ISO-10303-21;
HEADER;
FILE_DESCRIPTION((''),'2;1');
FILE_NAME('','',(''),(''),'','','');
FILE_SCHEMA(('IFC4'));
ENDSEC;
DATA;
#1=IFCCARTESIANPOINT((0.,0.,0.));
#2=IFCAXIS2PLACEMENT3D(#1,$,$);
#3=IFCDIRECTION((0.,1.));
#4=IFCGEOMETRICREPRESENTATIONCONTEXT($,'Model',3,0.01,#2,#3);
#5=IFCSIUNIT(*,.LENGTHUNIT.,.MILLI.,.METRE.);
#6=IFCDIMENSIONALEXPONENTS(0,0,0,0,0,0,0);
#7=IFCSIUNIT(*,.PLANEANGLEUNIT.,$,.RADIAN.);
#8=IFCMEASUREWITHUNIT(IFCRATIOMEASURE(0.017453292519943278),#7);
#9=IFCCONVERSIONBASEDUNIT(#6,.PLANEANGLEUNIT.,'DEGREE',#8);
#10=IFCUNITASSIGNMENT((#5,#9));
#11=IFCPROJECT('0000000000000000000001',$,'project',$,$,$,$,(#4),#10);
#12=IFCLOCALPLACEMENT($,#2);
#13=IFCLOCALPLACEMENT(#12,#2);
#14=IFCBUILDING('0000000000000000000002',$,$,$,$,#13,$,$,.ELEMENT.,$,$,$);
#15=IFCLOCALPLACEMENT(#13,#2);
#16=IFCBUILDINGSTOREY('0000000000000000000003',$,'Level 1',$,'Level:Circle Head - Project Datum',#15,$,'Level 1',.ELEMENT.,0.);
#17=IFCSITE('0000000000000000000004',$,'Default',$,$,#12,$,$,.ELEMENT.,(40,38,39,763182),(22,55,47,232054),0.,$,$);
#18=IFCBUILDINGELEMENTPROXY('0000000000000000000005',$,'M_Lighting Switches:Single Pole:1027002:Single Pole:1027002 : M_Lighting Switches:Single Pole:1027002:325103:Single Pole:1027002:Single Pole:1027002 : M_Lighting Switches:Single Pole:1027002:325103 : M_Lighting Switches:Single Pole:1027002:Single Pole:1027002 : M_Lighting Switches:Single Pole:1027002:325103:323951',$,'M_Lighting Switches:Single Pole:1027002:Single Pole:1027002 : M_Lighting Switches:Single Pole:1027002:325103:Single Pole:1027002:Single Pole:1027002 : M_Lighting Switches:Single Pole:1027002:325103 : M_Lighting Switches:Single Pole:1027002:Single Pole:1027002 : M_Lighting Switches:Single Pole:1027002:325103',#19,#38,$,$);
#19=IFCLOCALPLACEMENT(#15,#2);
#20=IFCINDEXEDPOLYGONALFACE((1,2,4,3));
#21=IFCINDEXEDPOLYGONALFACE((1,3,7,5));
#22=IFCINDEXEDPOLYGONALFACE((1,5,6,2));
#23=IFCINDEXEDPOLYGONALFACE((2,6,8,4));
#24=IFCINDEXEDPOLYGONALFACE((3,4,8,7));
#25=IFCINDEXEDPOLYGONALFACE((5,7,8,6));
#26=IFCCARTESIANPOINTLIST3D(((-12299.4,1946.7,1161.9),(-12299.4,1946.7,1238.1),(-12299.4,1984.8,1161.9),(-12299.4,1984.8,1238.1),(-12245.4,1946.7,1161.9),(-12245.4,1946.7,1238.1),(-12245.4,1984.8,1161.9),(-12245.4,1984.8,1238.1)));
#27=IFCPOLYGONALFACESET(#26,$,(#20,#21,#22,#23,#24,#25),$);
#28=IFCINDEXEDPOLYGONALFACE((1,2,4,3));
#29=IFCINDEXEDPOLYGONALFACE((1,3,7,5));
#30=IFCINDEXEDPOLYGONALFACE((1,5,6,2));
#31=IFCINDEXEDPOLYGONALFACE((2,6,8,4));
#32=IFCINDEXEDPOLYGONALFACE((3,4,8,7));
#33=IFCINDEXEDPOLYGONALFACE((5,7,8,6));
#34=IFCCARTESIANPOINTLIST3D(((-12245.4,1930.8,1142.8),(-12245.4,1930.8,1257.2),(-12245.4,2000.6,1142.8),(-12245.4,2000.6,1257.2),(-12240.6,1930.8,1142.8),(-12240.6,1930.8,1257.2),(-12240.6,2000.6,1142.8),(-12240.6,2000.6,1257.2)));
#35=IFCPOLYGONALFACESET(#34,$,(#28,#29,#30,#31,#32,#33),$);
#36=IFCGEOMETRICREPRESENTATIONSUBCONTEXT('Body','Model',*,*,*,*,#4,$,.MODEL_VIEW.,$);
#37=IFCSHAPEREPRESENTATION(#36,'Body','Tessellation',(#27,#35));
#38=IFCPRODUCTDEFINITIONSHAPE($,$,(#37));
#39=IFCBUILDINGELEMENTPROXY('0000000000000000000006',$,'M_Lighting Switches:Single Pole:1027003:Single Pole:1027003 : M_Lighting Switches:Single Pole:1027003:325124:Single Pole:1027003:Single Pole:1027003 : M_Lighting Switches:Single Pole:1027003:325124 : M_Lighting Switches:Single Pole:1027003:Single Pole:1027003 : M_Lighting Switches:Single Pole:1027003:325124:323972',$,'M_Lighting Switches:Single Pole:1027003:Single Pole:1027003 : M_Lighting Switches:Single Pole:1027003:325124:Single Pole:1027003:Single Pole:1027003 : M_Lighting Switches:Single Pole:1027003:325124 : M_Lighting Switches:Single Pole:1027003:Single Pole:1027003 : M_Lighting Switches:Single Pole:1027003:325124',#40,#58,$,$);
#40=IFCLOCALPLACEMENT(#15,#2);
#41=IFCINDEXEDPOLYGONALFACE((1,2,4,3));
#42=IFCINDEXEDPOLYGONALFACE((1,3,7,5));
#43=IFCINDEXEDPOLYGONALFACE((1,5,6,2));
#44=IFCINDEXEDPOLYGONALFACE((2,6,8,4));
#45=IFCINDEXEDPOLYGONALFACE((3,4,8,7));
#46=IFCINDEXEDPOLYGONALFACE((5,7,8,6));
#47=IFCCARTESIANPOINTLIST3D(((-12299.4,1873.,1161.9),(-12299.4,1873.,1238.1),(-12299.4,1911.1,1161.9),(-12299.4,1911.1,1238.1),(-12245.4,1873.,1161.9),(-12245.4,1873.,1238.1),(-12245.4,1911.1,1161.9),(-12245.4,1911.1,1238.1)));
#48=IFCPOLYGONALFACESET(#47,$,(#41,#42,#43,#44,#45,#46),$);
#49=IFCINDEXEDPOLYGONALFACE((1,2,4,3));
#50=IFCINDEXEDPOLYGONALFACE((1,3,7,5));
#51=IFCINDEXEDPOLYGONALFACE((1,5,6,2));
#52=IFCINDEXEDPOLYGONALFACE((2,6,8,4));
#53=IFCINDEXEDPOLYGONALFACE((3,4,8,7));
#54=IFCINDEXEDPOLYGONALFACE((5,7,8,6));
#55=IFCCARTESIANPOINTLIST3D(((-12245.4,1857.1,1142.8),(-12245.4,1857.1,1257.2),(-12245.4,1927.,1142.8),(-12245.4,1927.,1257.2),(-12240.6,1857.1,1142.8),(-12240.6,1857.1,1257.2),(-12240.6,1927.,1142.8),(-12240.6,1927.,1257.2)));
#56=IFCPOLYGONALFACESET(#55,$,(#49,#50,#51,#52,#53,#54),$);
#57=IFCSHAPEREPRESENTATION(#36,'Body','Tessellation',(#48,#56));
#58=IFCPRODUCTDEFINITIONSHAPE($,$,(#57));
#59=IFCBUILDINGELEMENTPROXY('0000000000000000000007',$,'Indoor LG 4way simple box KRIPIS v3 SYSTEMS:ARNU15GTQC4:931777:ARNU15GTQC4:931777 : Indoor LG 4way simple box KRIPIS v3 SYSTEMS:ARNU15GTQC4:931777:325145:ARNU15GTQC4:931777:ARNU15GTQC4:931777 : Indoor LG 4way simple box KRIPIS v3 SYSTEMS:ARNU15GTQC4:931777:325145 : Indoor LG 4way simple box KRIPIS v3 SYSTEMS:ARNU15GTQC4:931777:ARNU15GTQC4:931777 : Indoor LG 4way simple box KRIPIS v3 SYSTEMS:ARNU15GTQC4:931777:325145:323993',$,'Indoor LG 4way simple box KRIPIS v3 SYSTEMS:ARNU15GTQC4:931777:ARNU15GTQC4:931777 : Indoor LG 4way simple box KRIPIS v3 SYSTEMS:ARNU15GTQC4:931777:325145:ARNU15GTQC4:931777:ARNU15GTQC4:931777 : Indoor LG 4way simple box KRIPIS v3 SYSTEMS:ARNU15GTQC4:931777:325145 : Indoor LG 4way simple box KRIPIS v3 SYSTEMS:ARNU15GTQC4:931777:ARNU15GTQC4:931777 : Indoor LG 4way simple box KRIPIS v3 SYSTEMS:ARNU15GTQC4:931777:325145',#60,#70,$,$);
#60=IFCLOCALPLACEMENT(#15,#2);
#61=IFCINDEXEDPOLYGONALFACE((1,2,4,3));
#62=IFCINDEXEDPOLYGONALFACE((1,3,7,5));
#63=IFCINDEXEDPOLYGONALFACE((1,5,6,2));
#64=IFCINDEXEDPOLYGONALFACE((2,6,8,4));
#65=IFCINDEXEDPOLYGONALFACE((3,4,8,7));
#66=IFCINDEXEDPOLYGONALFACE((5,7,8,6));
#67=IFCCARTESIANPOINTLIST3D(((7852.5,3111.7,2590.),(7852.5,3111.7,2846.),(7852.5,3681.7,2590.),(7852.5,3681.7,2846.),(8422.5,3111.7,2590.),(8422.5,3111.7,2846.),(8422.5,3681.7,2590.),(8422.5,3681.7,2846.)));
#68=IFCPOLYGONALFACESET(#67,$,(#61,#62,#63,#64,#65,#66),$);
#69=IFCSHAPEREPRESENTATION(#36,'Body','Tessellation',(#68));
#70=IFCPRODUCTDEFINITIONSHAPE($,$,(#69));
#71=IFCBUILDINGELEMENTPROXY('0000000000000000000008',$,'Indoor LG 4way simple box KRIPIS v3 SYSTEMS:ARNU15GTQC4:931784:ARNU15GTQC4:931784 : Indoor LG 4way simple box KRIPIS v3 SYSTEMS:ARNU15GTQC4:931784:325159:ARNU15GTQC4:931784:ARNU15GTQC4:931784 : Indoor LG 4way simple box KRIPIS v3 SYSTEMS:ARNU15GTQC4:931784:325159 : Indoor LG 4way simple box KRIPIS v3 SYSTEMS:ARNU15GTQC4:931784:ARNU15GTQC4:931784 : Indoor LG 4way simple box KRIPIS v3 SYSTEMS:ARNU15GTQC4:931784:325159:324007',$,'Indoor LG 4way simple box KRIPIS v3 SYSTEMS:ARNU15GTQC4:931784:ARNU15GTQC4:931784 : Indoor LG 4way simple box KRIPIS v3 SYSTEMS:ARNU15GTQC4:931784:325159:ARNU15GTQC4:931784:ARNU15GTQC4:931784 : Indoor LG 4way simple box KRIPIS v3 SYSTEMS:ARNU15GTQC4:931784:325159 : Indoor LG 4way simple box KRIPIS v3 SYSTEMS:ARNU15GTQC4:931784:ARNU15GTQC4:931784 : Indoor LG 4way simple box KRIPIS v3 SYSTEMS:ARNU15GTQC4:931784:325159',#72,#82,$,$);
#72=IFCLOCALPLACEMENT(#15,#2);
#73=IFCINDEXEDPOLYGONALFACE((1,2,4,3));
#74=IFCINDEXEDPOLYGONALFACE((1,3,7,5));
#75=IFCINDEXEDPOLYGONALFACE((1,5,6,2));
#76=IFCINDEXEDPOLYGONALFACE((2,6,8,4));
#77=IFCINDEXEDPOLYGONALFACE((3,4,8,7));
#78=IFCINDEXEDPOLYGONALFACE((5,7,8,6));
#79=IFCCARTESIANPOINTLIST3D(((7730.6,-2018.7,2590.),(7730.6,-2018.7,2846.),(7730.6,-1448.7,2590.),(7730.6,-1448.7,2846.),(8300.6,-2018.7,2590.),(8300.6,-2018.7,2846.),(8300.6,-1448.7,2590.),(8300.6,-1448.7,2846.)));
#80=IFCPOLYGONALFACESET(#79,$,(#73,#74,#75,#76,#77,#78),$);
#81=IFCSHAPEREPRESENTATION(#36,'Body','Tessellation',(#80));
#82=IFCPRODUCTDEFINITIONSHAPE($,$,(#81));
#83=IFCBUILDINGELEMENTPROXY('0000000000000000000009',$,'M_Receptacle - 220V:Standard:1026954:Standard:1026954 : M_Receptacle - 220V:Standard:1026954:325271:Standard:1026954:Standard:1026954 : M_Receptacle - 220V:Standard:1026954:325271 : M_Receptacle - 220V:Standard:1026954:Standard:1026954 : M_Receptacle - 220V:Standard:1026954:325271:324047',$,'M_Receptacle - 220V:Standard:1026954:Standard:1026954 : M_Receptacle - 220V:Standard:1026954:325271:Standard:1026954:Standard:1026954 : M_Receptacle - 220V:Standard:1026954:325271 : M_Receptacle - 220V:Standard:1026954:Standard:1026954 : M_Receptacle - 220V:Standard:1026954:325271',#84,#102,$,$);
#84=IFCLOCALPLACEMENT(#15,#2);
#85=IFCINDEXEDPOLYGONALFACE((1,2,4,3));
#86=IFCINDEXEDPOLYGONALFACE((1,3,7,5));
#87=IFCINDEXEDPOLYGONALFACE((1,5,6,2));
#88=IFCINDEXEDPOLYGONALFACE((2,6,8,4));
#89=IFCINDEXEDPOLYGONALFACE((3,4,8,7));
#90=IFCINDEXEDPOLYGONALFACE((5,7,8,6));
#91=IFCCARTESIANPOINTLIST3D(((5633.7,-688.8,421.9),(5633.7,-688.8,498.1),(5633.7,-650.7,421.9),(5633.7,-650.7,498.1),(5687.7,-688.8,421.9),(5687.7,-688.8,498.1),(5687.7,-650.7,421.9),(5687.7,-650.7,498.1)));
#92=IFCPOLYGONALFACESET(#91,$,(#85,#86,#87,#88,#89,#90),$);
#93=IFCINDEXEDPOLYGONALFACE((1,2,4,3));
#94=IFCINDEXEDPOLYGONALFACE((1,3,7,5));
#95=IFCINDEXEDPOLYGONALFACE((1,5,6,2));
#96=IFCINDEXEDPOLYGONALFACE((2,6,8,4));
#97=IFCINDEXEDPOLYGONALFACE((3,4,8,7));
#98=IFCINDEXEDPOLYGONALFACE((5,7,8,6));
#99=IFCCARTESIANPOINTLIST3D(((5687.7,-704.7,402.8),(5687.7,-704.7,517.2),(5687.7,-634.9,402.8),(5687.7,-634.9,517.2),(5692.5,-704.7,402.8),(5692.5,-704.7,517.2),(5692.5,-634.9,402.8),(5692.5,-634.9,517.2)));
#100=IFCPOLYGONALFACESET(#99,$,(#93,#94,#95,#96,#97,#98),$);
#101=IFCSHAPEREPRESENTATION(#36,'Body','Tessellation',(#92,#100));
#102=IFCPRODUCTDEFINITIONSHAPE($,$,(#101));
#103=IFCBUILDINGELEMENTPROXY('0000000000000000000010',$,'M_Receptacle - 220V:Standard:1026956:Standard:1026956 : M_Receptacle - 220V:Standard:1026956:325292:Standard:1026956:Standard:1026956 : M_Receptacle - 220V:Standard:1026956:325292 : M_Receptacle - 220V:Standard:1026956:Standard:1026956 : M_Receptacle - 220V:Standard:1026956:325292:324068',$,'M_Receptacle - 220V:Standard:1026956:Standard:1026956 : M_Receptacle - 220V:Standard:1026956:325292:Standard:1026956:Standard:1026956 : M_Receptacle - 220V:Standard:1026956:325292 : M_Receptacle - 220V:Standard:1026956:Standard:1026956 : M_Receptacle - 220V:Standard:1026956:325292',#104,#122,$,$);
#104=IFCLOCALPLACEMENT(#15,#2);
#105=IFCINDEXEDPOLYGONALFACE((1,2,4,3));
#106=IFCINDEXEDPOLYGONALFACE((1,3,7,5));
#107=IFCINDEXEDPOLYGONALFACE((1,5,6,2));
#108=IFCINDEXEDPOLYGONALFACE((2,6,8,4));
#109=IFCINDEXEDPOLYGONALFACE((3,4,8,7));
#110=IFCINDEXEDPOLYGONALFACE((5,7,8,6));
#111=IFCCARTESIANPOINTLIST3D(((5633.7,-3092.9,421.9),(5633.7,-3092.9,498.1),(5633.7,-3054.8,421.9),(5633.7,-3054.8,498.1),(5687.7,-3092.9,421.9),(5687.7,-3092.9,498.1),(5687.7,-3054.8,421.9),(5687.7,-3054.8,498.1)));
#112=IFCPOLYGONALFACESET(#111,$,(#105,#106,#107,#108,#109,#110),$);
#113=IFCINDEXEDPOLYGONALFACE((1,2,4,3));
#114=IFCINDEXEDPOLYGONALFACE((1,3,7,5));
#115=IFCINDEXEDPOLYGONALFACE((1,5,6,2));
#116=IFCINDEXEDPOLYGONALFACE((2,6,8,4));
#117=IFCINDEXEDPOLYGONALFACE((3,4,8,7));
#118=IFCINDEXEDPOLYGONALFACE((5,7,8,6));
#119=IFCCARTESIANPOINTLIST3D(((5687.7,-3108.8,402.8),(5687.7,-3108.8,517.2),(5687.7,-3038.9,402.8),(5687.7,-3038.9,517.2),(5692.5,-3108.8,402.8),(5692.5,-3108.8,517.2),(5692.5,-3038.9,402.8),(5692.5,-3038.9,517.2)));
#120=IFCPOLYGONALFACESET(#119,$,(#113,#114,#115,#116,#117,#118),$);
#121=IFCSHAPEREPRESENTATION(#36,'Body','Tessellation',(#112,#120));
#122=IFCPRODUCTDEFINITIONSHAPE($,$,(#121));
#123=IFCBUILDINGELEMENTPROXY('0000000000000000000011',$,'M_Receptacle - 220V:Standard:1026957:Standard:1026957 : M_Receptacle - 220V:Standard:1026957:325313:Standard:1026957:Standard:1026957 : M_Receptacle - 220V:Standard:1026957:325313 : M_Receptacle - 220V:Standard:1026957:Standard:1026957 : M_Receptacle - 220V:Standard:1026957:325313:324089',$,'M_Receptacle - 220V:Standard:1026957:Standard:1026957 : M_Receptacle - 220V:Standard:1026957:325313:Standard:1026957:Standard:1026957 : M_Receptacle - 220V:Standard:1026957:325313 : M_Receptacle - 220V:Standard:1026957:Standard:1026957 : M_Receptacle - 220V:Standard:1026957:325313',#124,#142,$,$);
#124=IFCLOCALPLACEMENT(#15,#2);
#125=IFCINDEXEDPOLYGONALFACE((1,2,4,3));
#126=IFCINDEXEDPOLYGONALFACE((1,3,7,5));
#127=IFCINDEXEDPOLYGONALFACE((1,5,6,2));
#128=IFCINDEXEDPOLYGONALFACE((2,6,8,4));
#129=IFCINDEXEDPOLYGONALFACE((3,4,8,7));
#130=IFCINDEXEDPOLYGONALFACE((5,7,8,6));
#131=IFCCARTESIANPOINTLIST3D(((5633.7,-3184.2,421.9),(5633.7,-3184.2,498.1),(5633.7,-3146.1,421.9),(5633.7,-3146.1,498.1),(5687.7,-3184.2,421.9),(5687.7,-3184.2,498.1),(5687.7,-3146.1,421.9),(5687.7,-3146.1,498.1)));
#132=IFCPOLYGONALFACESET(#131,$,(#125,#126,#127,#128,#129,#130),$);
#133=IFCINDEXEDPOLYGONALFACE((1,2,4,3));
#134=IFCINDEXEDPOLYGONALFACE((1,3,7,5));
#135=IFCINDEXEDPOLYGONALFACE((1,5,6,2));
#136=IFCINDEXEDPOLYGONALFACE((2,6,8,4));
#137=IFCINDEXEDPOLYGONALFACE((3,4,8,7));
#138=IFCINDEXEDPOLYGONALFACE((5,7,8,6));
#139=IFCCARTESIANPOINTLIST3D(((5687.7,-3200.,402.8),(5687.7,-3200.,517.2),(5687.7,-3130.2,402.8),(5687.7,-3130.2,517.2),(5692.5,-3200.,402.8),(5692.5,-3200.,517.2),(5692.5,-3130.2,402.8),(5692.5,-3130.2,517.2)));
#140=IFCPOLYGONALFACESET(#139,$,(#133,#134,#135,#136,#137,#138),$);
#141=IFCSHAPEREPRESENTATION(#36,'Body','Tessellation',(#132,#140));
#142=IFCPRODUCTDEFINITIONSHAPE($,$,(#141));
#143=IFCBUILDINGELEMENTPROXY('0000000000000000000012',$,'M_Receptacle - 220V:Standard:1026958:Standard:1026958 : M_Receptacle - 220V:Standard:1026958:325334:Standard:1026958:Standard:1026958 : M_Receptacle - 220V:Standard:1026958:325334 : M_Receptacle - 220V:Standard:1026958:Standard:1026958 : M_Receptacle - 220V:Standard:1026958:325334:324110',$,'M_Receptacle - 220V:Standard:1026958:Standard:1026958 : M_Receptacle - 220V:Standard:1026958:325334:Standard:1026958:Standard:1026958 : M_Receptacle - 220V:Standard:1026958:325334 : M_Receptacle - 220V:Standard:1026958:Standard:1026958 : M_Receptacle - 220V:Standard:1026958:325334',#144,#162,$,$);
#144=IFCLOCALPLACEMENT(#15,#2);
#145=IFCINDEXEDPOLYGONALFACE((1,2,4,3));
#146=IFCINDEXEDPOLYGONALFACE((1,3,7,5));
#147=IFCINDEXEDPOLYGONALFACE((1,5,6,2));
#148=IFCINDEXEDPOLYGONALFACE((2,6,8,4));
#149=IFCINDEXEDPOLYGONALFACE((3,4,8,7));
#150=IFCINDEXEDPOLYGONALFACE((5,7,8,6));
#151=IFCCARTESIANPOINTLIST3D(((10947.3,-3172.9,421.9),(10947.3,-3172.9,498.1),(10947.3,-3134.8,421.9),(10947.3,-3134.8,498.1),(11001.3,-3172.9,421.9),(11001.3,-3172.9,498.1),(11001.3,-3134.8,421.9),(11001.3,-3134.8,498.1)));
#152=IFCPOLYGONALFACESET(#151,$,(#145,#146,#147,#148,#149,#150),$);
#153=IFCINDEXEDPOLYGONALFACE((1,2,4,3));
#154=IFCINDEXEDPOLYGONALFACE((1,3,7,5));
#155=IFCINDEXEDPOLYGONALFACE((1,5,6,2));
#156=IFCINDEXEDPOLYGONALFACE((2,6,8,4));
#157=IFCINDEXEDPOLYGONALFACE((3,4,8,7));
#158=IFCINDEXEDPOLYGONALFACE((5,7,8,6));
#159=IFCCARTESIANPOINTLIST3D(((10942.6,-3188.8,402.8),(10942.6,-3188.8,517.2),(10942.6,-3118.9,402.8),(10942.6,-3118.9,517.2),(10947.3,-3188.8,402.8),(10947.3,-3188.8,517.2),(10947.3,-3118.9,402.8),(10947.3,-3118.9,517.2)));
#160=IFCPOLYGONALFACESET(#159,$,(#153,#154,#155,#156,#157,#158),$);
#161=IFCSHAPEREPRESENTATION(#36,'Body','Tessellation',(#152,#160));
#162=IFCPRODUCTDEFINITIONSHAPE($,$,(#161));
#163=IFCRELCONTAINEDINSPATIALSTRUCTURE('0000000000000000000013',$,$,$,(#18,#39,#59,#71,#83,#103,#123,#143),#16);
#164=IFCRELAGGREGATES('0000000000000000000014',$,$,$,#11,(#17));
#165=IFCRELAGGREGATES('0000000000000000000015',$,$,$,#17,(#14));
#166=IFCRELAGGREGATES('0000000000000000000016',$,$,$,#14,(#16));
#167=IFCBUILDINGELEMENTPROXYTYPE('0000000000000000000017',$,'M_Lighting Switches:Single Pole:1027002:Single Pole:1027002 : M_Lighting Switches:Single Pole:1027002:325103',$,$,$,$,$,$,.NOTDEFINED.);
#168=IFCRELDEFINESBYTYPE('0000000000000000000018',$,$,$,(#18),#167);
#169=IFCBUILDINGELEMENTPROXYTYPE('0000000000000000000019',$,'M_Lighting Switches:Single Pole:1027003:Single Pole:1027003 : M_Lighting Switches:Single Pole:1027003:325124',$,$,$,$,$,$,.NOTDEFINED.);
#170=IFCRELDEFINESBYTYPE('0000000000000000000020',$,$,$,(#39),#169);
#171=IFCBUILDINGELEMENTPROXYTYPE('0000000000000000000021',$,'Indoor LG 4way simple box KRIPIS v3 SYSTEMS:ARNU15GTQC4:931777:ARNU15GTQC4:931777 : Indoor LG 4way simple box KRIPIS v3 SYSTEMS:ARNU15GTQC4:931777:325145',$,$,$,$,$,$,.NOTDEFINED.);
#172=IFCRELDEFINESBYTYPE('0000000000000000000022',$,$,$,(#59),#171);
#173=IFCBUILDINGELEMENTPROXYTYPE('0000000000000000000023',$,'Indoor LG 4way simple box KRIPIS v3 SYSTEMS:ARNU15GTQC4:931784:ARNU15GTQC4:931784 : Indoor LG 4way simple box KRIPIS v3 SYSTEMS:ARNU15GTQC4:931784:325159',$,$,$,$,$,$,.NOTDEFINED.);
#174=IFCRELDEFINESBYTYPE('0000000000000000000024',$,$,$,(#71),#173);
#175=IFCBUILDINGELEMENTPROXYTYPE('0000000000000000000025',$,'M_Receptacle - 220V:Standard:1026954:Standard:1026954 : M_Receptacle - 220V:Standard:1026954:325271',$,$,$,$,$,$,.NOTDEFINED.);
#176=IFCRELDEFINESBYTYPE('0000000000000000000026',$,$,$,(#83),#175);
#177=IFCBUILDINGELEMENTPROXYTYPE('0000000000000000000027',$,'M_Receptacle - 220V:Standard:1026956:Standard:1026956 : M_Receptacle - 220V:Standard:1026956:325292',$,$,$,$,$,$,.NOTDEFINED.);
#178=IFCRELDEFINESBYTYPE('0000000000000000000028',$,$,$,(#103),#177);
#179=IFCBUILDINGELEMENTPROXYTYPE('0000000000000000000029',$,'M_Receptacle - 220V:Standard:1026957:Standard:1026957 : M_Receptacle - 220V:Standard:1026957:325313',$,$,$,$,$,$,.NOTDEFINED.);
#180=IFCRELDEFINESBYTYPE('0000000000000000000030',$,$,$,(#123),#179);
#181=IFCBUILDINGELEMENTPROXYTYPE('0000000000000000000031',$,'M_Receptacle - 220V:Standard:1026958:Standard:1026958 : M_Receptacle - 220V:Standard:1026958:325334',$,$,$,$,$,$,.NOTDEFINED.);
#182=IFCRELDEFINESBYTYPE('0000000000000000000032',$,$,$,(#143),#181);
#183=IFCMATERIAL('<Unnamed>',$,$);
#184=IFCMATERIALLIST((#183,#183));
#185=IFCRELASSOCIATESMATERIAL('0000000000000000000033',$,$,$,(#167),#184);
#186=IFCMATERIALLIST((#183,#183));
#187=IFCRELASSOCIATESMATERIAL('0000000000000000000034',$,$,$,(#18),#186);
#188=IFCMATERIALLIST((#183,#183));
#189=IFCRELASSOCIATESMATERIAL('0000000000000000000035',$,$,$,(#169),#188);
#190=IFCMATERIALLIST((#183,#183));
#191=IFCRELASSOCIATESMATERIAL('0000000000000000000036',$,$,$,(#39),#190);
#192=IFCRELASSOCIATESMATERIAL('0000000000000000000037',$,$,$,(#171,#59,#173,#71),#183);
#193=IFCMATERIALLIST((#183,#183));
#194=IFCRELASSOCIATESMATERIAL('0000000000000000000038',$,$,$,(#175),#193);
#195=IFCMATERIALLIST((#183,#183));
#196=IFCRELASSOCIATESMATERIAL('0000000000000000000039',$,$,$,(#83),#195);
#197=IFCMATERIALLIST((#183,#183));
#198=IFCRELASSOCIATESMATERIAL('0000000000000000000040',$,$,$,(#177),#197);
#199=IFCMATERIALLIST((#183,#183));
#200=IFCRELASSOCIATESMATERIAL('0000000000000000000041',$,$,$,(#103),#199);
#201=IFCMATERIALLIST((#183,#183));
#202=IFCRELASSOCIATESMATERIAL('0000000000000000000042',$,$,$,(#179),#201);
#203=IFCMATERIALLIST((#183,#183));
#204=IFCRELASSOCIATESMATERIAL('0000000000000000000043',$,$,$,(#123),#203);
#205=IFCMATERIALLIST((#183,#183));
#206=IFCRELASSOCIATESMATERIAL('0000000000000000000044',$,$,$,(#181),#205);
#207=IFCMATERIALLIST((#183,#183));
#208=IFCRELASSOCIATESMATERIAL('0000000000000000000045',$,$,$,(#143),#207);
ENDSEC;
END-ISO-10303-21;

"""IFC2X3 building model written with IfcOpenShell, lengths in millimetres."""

from ifc_helpers import new_model, entity, si_unit, converted_unit, direction, frame, frame_2d, origin, origin_2d_with_axis, place, context, subcontext, project, spatial, rectangle, extrude, source, transform, mapped, material, material_list, type_object, type_shapes, element, save


model = new_model("IFC2X3")

# Units and contexts
model_context = context("Model", 3, precision=0.01, world=origin(), true_north=direction((0.0, 1.0)))
body_context = subcontext(model_context, "Body", "Model", "MODEL_VIEW")
ifc_project = project(units=[si_unit("LENGTHUNIT", "METRE", prefix="MILLI"), converted_unit("PLANEANGLEUNIT", "DEGREE", entity("IfcRatioMeasure", 0.017453292519943278), si_unit("PLANEANGLEUNIT", "RADIAN"), dimensions=[0, 0, 0, 0, 0, 0, 0])], contexts=[model_context])

# Site, building, storey
site_placement = place(None, origin())
site = spatial("IfcSite", under=ifc_project, at=site_placement, Name="Default", CompositionType="ELEMENT", RefLatitude=(40, 38, 39, 763182), RefLongitude=(22, 55, 47, 232054), RefElevation=0.0)
building_placement = place(site_placement, origin())
building = spatial("IfcBuilding", under=site, at=building_placement, CompositionType="ELEMENT")
storey_placement = place(building_placement, origin())
storey = spatial("IfcBuildingStorey", under=building, at=storey_placement, Name="Level 1", ObjectType="Level:Circle Head - Project Datum", LongName="Level 1", CompositionType="ELEMENT", Elevation=0.0)

# Shared definitions
ifc_material = material(Name="<Unnamed>")

# Building element proxies
ifc_material_list_1 = material_list([ifc_material, ifc_material])
ifc_material_list_2 = material_list([ifc_material, ifc_material])
building_element_proxy_type_1 = type_object("IfcBuildingElementProxyType", Name="M_Lighting Switches:Single Pole:1027002:Single Pole:1027002 : M_Lighting Switches:Single Pole:1027002:325103", PredefinedType="NOTDEFINED", material=ifc_material_list_2)
shared_shape_1 = source(origin(), body_context, "Body", "SweptSolid", [
    extrude(rectangle(XDim=38.1, YDim=54.0, at=frame_2d((0.0, 0.0), x_axis=(1.0, 0.0))), frame((-12272.4, 1965.7, 1161.9), z_axis=(0.0, 0.0, 1.0), x_axis=(0.0, -1.0, 0.0)), (0.0, 0.0, 1.0), 76.2),
    extrude(rectangle(XDim=69.8, YDim=4.8, at=origin_2d_with_axis()), frame((-12243.0, 1965.7, 1142.8), z_axis=(0.0, 0.0, 1.0), x_axis=(0.0, -1.0, 0.0)), (0.0, 0.0, 1.0), 114.3),
])
type_shapes(building_element_proxy_type_1, [shared_shape_1])
proxy_1_placement = place(storey_placement, origin())
element("IfcBuildingElementProxy", 1, at=proxy_1_placement, inside=storey, type_object=building_element_proxy_type_1, material=ifc_material_list_1, Name="M_Lighting Switches:Single Pole:1027002:Single Pole:1027002 : M_Lighting Switches:Single Pole:1027002:325103:Single Pole:1027002:Single Pole:1027002 : M_Lighting Switches:Single Pole:1027002:325103 : M_Lighting Switches:Single Pole:1027002:Single Pole:1027002 : M_Lighting Switches:Single Pole:1027002:325103:323951", ObjectType="M_Lighting Switches:Single Pole:1027002:Single Pole:1027002 : M_Lighting Switches:Single Pole:1027002:325103:Single Pole:1027002:Single Pole:1027002 : M_Lighting Switches:Single Pole:1027002:325103 : M_Lighting Switches:Single Pole:1027002:Single Pole:1027002 : M_Lighting Switches:Single Pole:1027002:325103", context=body_context, shape_type="MappedRepresentation", body=[
    mapped(shared_shape_1, transform((0.0, 0.0, 0.0), scale=1.0)),
])
ifc_material_list_3 = material_list([ifc_material, ifc_material])
ifc_material_list_4 = material_list([ifc_material, ifc_material])
building_element_proxy_type_2 = type_object("IfcBuildingElementProxyType", Name="M_Lighting Switches:Single Pole:1027003:Single Pole:1027003 : M_Lighting Switches:Single Pole:1027003:325124", PredefinedType="NOTDEFINED", material=ifc_material_list_4)
shared_shape_2 = source(origin(), body_context, "Body", "SweptSolid", [
    extrude(rectangle(XDim=38.1, YDim=54.0, at=frame_2d((0.0, 0.0), x_axis=(1.0, 0.0))), frame((-12272.4, 1892.0, 1161.9), z_axis=(0.0, 0.0, 1.0), x_axis=(0.0, -1.0, 0.0)), (0.0, 0.0, 1.0), 76.2),
    extrude(rectangle(XDim=69.8, YDim=4.8, at=origin_2d_with_axis()), frame((-12243.0, 1892.0, 1142.8), z_axis=(0.0, 0.0, 1.0), x_axis=(0.0, -1.0, 0.0)), (0.0, 0.0, 1.0), 114.3),
])
type_shapes(building_element_proxy_type_2, [shared_shape_2])
proxy_2_placement = place(storey_placement, origin())
element("IfcBuildingElementProxy", 2, at=proxy_2_placement, inside=storey, type_object=building_element_proxy_type_2, material=ifc_material_list_3, Name="M_Lighting Switches:Single Pole:1027003:Single Pole:1027003 : M_Lighting Switches:Single Pole:1027003:325124:Single Pole:1027003:Single Pole:1027003 : M_Lighting Switches:Single Pole:1027003:325124 : M_Lighting Switches:Single Pole:1027003:Single Pole:1027003 : M_Lighting Switches:Single Pole:1027003:325124:323972", ObjectType="M_Lighting Switches:Single Pole:1027003:Single Pole:1027003 : M_Lighting Switches:Single Pole:1027003:325124:Single Pole:1027003:Single Pole:1027003 : M_Lighting Switches:Single Pole:1027003:325124 : M_Lighting Switches:Single Pole:1027003:Single Pole:1027003 : M_Lighting Switches:Single Pole:1027003:325124", context=body_context, shape_type="MappedRepresentation", body=[
    mapped(shared_shape_2, transform((0.0, 0.0, 0.0), scale=1.0)),
])
building_element_proxy_type_3 = type_object("IfcBuildingElementProxyType", Name="Indoor LG 4way simple box KRIPIS v3 SYSTEMS:ARNU15GTQC4:931777:ARNU15GTQC4:931777 : Indoor LG 4way simple box KRIPIS v3 SYSTEMS:ARNU15GTQC4:931777:325145", PredefinedType="NOTDEFINED", material=ifc_material)
shared_shape_3 = source(origin(), body_context, "Body", "SweptSolid", [
    extrude(rectangle(XDim=570.0, YDim=570.0, at=origin_2d_with_axis()), frame((8137.5, 3396.7, 2590.0), z_axis=(0.0, 0.0, 1.0), x_axis=(0.0, 1.0, 0.0)), (0.0, 0.0, 1.0), 256.0),
])
type_shapes(building_element_proxy_type_3, [shared_shape_3])
proxy_3_placement = place(storey_placement, origin())
element("IfcBuildingElementProxy", 3, at=proxy_3_placement, inside=storey, type_object=building_element_proxy_type_3, material=ifc_material, Name="Indoor LG 4way simple box KRIPIS v3 SYSTEMS:ARNU15GTQC4:931777:ARNU15GTQC4:931777 : Indoor LG 4way simple box KRIPIS v3 SYSTEMS:ARNU15GTQC4:931777:325145:ARNU15GTQC4:931777:ARNU15GTQC4:931777 : Indoor LG 4way simple box KRIPIS v3 SYSTEMS:ARNU15GTQC4:931777:325145 : Indoor LG 4way simple box KRIPIS v3 SYSTEMS:ARNU15GTQC4:931777:ARNU15GTQC4:931777 : Indoor LG 4way simple box KRIPIS v3 SYSTEMS:ARNU15GTQC4:931777:325145:323993", ObjectType="Indoor LG 4way simple box KRIPIS v3 SYSTEMS:ARNU15GTQC4:931777:ARNU15GTQC4:931777 : Indoor LG 4way simple box KRIPIS v3 SYSTEMS:ARNU15GTQC4:931777:325145:ARNU15GTQC4:931777:ARNU15GTQC4:931777 : Indoor LG 4way simple box KRIPIS v3 SYSTEMS:ARNU15GTQC4:931777:325145 : Indoor LG 4way simple box KRIPIS v3 SYSTEMS:ARNU15GTQC4:931777:ARNU15GTQC4:931777 : Indoor LG 4way simple box KRIPIS v3 SYSTEMS:ARNU15GTQC4:931777:325145", context=body_context, shape_type="MappedRepresentation", body=[
    mapped(shared_shape_3, transform((0.0, 0.0, 0.0), scale=1.0)),
])
building_element_proxy_type_4 = type_object("IfcBuildingElementProxyType", Name="Indoor LG 4way simple box KRIPIS v3 SYSTEMS:ARNU15GTQC4:931784:ARNU15GTQC4:931784 : Indoor LG 4way simple box KRIPIS v3 SYSTEMS:ARNU15GTQC4:931784:325159", PredefinedType="NOTDEFINED", material=ifc_material)
shared_shape_4 = source(origin(), body_context, "Body", "SweptSolid", [
    extrude(rectangle(XDim=570.0, YDim=570.0, at=origin_2d_with_axis()), frame((8015.6, -1733.7, 2590.0), z_axis=(0.0, 0.0, 1.0), x_axis=(0.0, 1.0, 0.0)), (0.0, 0.0, 1.0), 256.0),
])
type_shapes(building_element_proxy_type_4, [shared_shape_4])
proxy_4_placement = place(storey_placement, origin())
element("IfcBuildingElementProxy", 4, at=proxy_4_placement, inside=storey, type_object=building_element_proxy_type_4, material=ifc_material, Name="Indoor LG 4way simple box KRIPIS v3 SYSTEMS:ARNU15GTQC4:931784:ARNU15GTQC4:931784 : Indoor LG 4way simple box KRIPIS v3 SYSTEMS:ARNU15GTQC4:931784:325159:ARNU15GTQC4:931784:ARNU15GTQC4:931784 : Indoor LG 4way simple box KRIPIS v3 SYSTEMS:ARNU15GTQC4:931784:325159 : Indoor LG 4way simple box KRIPIS v3 SYSTEMS:ARNU15GTQC4:931784:ARNU15GTQC4:931784 : Indoor LG 4way simple box KRIPIS v3 SYSTEMS:ARNU15GTQC4:931784:325159:324007", ObjectType="Indoor LG 4way simple box KRIPIS v3 SYSTEMS:ARNU15GTQC4:931784:ARNU15GTQC4:931784 : Indoor LG 4way simple box KRIPIS v3 SYSTEMS:ARNU15GTQC4:931784:325159:ARNU15GTQC4:931784:ARNU15GTQC4:931784 : Indoor LG 4way simple box KRIPIS v3 SYSTEMS:ARNU15GTQC4:931784:325159 : Indoor LG 4way simple box KRIPIS v3 SYSTEMS:ARNU15GTQC4:931784:ARNU15GTQC4:931784 : Indoor LG 4way simple box KRIPIS v3 SYSTEMS:ARNU15GTQC4:931784:325159", context=body_context, shape_type="MappedRepresentation", body=[
    mapped(shared_shape_4, transform((0.0, 0.0, 0.0), scale=1.0)),
])
ifc_material_list_5 = material_list([ifc_material, ifc_material])
ifc_material_list_6 = material_list([ifc_material, ifc_material])
building_element_proxy_type_5 = type_object("IfcBuildingElementProxyType", Name="M_Receptacle - 220V:Standard:1026954:Standard:1026954 : M_Receptacle - 220V:Standard:1026954:325271", PredefinedType="NOTDEFINED", material=ifc_material_list_6)
shared_shape_5 = source(origin(), body_context, "Body", "SweptSolid", [
    extrude(rectangle(XDim=38.1, YDim=54.0, at=origin_2d_with_axis()), frame((5660.7, -669.8, 421.9), z_axis=(0.0, 0.0, 1.0), x_axis=(0.0, -1.0, 0.0)), (0.0, 0.0, 1.0), 76.2),
    extrude(rectangle(XDim=69.8, YDim=4.8, at=origin_2d_with_axis()), frame((5690.1, -669.8, 402.8), z_axis=(0.0, 0.0, 1.0), x_axis=(0.0, -1.0, 0.0)), (0.0, 0.0, 1.0), 114.3),
])
type_shapes(building_element_proxy_type_5, [shared_shape_5])
proxy_5_placement = place(storey_placement, origin())
element("IfcBuildingElementProxy", 5, at=proxy_5_placement, inside=storey, type_object=building_element_proxy_type_5, material=ifc_material_list_5, Name="M_Receptacle - 220V:Standard:1026954:Standard:1026954 : M_Receptacle - 220V:Standard:1026954:325271:Standard:1026954:Standard:1026954 : M_Receptacle - 220V:Standard:1026954:325271 : M_Receptacle - 220V:Standard:1026954:Standard:1026954 : M_Receptacle - 220V:Standard:1026954:325271:324047", ObjectType="M_Receptacle - 220V:Standard:1026954:Standard:1026954 : M_Receptacle - 220V:Standard:1026954:325271:Standard:1026954:Standard:1026954 : M_Receptacle - 220V:Standard:1026954:325271 : M_Receptacle - 220V:Standard:1026954:Standard:1026954 : M_Receptacle - 220V:Standard:1026954:325271", context=body_context, shape_type="MappedRepresentation", body=[
    mapped(shared_shape_5, transform((0.0, 0.0, 0.0), scale=1.0)),
])
ifc_material_list_7 = material_list([ifc_material, ifc_material])
ifc_material_list_8 = material_list([ifc_material, ifc_material])
building_element_proxy_type_6 = type_object("IfcBuildingElementProxyType", Name="M_Receptacle - 220V:Standard:1026956:Standard:1026956 : M_Receptacle - 220V:Standard:1026956:325292", PredefinedType="NOTDEFINED", material=ifc_material_list_8)
shared_shape_6 = source(origin(), body_context, "Body", "SweptSolid", [
    extrude(rectangle(XDim=38.1, YDim=54.0, at=frame_2d((0.0, 0.0), x_axis=(1.0, 0.0))), frame((5660.7, -3073.8, 421.9), z_axis=(0.0, 0.0, 1.0), x_axis=(0.0, -1.0, 0.0)), (0.0, 0.0, 1.0), 76.2),
    extrude(rectangle(XDim=69.8, YDim=4.8, at=frame_2d((0.0, 0.0), x_axis=(1.0, 0.0))), frame((5690.1, -3073.8, 402.8), z_axis=(0.0, 0.0, 1.0), x_axis=(0.0, -1.0, 0.0)), (0.0, 0.0, 1.0), 114.3),
])
type_shapes(building_element_proxy_type_6, [shared_shape_6])
proxy_6_placement = place(storey_placement, origin())
element("IfcBuildingElementProxy", 6, at=proxy_6_placement, inside=storey, type_object=building_element_proxy_type_6, material=ifc_material_list_7, Name="M_Receptacle - 220V:Standard:1026956:Standard:1026956 : M_Receptacle - 220V:Standard:1026956:325292:Standard:1026956:Standard:1026956 : M_Receptacle - 220V:Standard:1026956:325292 : M_Receptacle - 220V:Standard:1026956:Standard:1026956 : M_Receptacle - 220V:Standard:1026956:325292:324068", ObjectType="M_Receptacle - 220V:Standard:1026956:Standard:1026956 : M_Receptacle - 220V:Standard:1026956:325292:Standard:1026956:Standard:1026956 : M_Receptacle - 220V:Standard:1026956:325292 : M_Receptacle - 220V:Standard:1026956:Standard:1026956 : M_Receptacle - 220V:Standard:1026956:325292", context=body_context, shape_type="MappedRepresentation", body=[
    mapped(shared_shape_6, transform((0.0, 0.0, 0.0), scale=1.0)),
])
ifc_material_list_9 = material_list([ifc_material, ifc_material])
ifc_material_list_10 = material_list([ifc_material, ifc_material])
building_element_proxy_type_7 = type_object("IfcBuildingElementProxyType", Name="M_Receptacle - 220V:Standard:1026957:Standard:1026957 : M_Receptacle - 220V:Standard:1026957:325313", PredefinedType="NOTDEFINED", material=ifc_material_list_10)
shared_shape_7 = source(origin(), body_context, "Body", "SweptSolid", [
    extrude(rectangle(XDim=38.1, YDim=54.0, at=frame_2d((0.0, 0.0), x_axis=(1.0, 0.0))), frame((5660.7, -3165.1, 421.9), z_axis=(0.0, 0.0, 1.0), x_axis=(0.0, -1.0, 0.0)), (0.0, 0.0, 1.0), 76.2),
    extrude(rectangle(XDim=69.8, YDim=4.8, at=frame_2d((0.0, 0.0), x_axis=(1.0, 0.0))), frame((5690.1, -3165.1, 402.8), z_axis=(0.0, 0.0, 1.0), x_axis=(0.0, -1.0, 0.0)), (0.0, 0.0, 1.0), 114.3),
])
type_shapes(building_element_proxy_type_7, [shared_shape_7])
proxy_7_placement = place(storey_placement, origin())
element("IfcBuildingElementProxy", 7, at=proxy_7_placement, inside=storey, type_object=building_element_proxy_type_7, material=ifc_material_list_9, Name="M_Receptacle - 220V:Standard:1026957:Standard:1026957 : M_Receptacle - 220V:Standard:1026957:325313:Standard:1026957:Standard:1026957 : M_Receptacle - 220V:Standard:1026957:325313 : M_Receptacle - 220V:Standard:1026957:Standard:1026957 : M_Receptacle - 220V:Standard:1026957:325313:324089", ObjectType="M_Receptacle - 220V:Standard:1026957:Standard:1026957 : M_Receptacle - 220V:Standard:1026957:325313:Standard:1026957:Standard:1026957 : M_Receptacle - 220V:Standard:1026957:325313 : M_Receptacle - 220V:Standard:1026957:Standard:1026957 : M_Receptacle - 220V:Standard:1026957:325313", context=body_context, shape_type="MappedRepresentation", body=[
    mapped(shared_shape_7, transform((0.0, 0.0, 0.0), scale=1.0)),
])
ifc_material_list_11 = material_list([ifc_material, ifc_material])
ifc_material_list_12 = material_list([ifc_material, ifc_material])
building_element_proxy_type_8 = type_object("IfcBuildingElementProxyType", Name="M_Receptacle - 220V:Standard:1026958:Standard:1026958 : M_Receptacle - 220V:Standard:1026958:325334", PredefinedType="NOTDEFINED", material=ifc_material_list_12)
shared_shape_8 = source(origin(), body_context, "Body", "SweptSolid", [
    extrude(rectangle(XDim=38.1, YDim=54.0, at=frame_2d((0.0, 0.0), x_axis=(1.0, 0.0))), frame((10974.3, -3153.8, 421.9), z_axis=(0.0, 0.0, 1.0), x_axis=(0.0, 1.0, 0.0)), (0.0, 0.0, 1.0), 76.2),
    extrude(rectangle(XDim=69.8, YDim=4.8, at=frame_2d((0.0, 0.0), x_axis=(1.0, 0.0))), frame((10945.0, -3153.8, 402.8), z_axis=(0.0, 0.0, 1.0), x_axis=(0.0, 1.0, 0.0)), (0.0, 0.0, 1.0), 114.3),
])
type_shapes(building_element_proxy_type_8, [shared_shape_8])
proxy_8_placement = place(storey_placement, origin())
element("IfcBuildingElementProxy", 8, at=proxy_8_placement, inside=storey, type_object=building_element_proxy_type_8, material=ifc_material_list_11, Name="M_Receptacle - 220V:Standard:1026958:Standard:1026958 : M_Receptacle - 220V:Standard:1026958:325334:Standard:1026958:Standard:1026958 : M_Receptacle - 220V:Standard:1026958:325334 : M_Receptacle - 220V:Standard:1026958:Standard:1026958 : M_Receptacle - 220V:Standard:1026958:325334:324110", ObjectType="M_Receptacle - 220V:Standard:1026958:Standard:1026958 : M_Receptacle - 220V:Standard:1026958:325334:Standard:1026958:Standard:1026958 : M_Receptacle - 220V:Standard:1026958:325334 : M_Receptacle - 220V:Standard:1026958:Standard:1026958 : M_Receptacle - 220V:Standard:1026958:325334", context=body_context, shape_type="MappedRepresentation", body=[
    mapped(shared_shape_8, transform((0.0, 0.0, 0.0), scale=1.0)),
])

save(model, "model.ifc")
